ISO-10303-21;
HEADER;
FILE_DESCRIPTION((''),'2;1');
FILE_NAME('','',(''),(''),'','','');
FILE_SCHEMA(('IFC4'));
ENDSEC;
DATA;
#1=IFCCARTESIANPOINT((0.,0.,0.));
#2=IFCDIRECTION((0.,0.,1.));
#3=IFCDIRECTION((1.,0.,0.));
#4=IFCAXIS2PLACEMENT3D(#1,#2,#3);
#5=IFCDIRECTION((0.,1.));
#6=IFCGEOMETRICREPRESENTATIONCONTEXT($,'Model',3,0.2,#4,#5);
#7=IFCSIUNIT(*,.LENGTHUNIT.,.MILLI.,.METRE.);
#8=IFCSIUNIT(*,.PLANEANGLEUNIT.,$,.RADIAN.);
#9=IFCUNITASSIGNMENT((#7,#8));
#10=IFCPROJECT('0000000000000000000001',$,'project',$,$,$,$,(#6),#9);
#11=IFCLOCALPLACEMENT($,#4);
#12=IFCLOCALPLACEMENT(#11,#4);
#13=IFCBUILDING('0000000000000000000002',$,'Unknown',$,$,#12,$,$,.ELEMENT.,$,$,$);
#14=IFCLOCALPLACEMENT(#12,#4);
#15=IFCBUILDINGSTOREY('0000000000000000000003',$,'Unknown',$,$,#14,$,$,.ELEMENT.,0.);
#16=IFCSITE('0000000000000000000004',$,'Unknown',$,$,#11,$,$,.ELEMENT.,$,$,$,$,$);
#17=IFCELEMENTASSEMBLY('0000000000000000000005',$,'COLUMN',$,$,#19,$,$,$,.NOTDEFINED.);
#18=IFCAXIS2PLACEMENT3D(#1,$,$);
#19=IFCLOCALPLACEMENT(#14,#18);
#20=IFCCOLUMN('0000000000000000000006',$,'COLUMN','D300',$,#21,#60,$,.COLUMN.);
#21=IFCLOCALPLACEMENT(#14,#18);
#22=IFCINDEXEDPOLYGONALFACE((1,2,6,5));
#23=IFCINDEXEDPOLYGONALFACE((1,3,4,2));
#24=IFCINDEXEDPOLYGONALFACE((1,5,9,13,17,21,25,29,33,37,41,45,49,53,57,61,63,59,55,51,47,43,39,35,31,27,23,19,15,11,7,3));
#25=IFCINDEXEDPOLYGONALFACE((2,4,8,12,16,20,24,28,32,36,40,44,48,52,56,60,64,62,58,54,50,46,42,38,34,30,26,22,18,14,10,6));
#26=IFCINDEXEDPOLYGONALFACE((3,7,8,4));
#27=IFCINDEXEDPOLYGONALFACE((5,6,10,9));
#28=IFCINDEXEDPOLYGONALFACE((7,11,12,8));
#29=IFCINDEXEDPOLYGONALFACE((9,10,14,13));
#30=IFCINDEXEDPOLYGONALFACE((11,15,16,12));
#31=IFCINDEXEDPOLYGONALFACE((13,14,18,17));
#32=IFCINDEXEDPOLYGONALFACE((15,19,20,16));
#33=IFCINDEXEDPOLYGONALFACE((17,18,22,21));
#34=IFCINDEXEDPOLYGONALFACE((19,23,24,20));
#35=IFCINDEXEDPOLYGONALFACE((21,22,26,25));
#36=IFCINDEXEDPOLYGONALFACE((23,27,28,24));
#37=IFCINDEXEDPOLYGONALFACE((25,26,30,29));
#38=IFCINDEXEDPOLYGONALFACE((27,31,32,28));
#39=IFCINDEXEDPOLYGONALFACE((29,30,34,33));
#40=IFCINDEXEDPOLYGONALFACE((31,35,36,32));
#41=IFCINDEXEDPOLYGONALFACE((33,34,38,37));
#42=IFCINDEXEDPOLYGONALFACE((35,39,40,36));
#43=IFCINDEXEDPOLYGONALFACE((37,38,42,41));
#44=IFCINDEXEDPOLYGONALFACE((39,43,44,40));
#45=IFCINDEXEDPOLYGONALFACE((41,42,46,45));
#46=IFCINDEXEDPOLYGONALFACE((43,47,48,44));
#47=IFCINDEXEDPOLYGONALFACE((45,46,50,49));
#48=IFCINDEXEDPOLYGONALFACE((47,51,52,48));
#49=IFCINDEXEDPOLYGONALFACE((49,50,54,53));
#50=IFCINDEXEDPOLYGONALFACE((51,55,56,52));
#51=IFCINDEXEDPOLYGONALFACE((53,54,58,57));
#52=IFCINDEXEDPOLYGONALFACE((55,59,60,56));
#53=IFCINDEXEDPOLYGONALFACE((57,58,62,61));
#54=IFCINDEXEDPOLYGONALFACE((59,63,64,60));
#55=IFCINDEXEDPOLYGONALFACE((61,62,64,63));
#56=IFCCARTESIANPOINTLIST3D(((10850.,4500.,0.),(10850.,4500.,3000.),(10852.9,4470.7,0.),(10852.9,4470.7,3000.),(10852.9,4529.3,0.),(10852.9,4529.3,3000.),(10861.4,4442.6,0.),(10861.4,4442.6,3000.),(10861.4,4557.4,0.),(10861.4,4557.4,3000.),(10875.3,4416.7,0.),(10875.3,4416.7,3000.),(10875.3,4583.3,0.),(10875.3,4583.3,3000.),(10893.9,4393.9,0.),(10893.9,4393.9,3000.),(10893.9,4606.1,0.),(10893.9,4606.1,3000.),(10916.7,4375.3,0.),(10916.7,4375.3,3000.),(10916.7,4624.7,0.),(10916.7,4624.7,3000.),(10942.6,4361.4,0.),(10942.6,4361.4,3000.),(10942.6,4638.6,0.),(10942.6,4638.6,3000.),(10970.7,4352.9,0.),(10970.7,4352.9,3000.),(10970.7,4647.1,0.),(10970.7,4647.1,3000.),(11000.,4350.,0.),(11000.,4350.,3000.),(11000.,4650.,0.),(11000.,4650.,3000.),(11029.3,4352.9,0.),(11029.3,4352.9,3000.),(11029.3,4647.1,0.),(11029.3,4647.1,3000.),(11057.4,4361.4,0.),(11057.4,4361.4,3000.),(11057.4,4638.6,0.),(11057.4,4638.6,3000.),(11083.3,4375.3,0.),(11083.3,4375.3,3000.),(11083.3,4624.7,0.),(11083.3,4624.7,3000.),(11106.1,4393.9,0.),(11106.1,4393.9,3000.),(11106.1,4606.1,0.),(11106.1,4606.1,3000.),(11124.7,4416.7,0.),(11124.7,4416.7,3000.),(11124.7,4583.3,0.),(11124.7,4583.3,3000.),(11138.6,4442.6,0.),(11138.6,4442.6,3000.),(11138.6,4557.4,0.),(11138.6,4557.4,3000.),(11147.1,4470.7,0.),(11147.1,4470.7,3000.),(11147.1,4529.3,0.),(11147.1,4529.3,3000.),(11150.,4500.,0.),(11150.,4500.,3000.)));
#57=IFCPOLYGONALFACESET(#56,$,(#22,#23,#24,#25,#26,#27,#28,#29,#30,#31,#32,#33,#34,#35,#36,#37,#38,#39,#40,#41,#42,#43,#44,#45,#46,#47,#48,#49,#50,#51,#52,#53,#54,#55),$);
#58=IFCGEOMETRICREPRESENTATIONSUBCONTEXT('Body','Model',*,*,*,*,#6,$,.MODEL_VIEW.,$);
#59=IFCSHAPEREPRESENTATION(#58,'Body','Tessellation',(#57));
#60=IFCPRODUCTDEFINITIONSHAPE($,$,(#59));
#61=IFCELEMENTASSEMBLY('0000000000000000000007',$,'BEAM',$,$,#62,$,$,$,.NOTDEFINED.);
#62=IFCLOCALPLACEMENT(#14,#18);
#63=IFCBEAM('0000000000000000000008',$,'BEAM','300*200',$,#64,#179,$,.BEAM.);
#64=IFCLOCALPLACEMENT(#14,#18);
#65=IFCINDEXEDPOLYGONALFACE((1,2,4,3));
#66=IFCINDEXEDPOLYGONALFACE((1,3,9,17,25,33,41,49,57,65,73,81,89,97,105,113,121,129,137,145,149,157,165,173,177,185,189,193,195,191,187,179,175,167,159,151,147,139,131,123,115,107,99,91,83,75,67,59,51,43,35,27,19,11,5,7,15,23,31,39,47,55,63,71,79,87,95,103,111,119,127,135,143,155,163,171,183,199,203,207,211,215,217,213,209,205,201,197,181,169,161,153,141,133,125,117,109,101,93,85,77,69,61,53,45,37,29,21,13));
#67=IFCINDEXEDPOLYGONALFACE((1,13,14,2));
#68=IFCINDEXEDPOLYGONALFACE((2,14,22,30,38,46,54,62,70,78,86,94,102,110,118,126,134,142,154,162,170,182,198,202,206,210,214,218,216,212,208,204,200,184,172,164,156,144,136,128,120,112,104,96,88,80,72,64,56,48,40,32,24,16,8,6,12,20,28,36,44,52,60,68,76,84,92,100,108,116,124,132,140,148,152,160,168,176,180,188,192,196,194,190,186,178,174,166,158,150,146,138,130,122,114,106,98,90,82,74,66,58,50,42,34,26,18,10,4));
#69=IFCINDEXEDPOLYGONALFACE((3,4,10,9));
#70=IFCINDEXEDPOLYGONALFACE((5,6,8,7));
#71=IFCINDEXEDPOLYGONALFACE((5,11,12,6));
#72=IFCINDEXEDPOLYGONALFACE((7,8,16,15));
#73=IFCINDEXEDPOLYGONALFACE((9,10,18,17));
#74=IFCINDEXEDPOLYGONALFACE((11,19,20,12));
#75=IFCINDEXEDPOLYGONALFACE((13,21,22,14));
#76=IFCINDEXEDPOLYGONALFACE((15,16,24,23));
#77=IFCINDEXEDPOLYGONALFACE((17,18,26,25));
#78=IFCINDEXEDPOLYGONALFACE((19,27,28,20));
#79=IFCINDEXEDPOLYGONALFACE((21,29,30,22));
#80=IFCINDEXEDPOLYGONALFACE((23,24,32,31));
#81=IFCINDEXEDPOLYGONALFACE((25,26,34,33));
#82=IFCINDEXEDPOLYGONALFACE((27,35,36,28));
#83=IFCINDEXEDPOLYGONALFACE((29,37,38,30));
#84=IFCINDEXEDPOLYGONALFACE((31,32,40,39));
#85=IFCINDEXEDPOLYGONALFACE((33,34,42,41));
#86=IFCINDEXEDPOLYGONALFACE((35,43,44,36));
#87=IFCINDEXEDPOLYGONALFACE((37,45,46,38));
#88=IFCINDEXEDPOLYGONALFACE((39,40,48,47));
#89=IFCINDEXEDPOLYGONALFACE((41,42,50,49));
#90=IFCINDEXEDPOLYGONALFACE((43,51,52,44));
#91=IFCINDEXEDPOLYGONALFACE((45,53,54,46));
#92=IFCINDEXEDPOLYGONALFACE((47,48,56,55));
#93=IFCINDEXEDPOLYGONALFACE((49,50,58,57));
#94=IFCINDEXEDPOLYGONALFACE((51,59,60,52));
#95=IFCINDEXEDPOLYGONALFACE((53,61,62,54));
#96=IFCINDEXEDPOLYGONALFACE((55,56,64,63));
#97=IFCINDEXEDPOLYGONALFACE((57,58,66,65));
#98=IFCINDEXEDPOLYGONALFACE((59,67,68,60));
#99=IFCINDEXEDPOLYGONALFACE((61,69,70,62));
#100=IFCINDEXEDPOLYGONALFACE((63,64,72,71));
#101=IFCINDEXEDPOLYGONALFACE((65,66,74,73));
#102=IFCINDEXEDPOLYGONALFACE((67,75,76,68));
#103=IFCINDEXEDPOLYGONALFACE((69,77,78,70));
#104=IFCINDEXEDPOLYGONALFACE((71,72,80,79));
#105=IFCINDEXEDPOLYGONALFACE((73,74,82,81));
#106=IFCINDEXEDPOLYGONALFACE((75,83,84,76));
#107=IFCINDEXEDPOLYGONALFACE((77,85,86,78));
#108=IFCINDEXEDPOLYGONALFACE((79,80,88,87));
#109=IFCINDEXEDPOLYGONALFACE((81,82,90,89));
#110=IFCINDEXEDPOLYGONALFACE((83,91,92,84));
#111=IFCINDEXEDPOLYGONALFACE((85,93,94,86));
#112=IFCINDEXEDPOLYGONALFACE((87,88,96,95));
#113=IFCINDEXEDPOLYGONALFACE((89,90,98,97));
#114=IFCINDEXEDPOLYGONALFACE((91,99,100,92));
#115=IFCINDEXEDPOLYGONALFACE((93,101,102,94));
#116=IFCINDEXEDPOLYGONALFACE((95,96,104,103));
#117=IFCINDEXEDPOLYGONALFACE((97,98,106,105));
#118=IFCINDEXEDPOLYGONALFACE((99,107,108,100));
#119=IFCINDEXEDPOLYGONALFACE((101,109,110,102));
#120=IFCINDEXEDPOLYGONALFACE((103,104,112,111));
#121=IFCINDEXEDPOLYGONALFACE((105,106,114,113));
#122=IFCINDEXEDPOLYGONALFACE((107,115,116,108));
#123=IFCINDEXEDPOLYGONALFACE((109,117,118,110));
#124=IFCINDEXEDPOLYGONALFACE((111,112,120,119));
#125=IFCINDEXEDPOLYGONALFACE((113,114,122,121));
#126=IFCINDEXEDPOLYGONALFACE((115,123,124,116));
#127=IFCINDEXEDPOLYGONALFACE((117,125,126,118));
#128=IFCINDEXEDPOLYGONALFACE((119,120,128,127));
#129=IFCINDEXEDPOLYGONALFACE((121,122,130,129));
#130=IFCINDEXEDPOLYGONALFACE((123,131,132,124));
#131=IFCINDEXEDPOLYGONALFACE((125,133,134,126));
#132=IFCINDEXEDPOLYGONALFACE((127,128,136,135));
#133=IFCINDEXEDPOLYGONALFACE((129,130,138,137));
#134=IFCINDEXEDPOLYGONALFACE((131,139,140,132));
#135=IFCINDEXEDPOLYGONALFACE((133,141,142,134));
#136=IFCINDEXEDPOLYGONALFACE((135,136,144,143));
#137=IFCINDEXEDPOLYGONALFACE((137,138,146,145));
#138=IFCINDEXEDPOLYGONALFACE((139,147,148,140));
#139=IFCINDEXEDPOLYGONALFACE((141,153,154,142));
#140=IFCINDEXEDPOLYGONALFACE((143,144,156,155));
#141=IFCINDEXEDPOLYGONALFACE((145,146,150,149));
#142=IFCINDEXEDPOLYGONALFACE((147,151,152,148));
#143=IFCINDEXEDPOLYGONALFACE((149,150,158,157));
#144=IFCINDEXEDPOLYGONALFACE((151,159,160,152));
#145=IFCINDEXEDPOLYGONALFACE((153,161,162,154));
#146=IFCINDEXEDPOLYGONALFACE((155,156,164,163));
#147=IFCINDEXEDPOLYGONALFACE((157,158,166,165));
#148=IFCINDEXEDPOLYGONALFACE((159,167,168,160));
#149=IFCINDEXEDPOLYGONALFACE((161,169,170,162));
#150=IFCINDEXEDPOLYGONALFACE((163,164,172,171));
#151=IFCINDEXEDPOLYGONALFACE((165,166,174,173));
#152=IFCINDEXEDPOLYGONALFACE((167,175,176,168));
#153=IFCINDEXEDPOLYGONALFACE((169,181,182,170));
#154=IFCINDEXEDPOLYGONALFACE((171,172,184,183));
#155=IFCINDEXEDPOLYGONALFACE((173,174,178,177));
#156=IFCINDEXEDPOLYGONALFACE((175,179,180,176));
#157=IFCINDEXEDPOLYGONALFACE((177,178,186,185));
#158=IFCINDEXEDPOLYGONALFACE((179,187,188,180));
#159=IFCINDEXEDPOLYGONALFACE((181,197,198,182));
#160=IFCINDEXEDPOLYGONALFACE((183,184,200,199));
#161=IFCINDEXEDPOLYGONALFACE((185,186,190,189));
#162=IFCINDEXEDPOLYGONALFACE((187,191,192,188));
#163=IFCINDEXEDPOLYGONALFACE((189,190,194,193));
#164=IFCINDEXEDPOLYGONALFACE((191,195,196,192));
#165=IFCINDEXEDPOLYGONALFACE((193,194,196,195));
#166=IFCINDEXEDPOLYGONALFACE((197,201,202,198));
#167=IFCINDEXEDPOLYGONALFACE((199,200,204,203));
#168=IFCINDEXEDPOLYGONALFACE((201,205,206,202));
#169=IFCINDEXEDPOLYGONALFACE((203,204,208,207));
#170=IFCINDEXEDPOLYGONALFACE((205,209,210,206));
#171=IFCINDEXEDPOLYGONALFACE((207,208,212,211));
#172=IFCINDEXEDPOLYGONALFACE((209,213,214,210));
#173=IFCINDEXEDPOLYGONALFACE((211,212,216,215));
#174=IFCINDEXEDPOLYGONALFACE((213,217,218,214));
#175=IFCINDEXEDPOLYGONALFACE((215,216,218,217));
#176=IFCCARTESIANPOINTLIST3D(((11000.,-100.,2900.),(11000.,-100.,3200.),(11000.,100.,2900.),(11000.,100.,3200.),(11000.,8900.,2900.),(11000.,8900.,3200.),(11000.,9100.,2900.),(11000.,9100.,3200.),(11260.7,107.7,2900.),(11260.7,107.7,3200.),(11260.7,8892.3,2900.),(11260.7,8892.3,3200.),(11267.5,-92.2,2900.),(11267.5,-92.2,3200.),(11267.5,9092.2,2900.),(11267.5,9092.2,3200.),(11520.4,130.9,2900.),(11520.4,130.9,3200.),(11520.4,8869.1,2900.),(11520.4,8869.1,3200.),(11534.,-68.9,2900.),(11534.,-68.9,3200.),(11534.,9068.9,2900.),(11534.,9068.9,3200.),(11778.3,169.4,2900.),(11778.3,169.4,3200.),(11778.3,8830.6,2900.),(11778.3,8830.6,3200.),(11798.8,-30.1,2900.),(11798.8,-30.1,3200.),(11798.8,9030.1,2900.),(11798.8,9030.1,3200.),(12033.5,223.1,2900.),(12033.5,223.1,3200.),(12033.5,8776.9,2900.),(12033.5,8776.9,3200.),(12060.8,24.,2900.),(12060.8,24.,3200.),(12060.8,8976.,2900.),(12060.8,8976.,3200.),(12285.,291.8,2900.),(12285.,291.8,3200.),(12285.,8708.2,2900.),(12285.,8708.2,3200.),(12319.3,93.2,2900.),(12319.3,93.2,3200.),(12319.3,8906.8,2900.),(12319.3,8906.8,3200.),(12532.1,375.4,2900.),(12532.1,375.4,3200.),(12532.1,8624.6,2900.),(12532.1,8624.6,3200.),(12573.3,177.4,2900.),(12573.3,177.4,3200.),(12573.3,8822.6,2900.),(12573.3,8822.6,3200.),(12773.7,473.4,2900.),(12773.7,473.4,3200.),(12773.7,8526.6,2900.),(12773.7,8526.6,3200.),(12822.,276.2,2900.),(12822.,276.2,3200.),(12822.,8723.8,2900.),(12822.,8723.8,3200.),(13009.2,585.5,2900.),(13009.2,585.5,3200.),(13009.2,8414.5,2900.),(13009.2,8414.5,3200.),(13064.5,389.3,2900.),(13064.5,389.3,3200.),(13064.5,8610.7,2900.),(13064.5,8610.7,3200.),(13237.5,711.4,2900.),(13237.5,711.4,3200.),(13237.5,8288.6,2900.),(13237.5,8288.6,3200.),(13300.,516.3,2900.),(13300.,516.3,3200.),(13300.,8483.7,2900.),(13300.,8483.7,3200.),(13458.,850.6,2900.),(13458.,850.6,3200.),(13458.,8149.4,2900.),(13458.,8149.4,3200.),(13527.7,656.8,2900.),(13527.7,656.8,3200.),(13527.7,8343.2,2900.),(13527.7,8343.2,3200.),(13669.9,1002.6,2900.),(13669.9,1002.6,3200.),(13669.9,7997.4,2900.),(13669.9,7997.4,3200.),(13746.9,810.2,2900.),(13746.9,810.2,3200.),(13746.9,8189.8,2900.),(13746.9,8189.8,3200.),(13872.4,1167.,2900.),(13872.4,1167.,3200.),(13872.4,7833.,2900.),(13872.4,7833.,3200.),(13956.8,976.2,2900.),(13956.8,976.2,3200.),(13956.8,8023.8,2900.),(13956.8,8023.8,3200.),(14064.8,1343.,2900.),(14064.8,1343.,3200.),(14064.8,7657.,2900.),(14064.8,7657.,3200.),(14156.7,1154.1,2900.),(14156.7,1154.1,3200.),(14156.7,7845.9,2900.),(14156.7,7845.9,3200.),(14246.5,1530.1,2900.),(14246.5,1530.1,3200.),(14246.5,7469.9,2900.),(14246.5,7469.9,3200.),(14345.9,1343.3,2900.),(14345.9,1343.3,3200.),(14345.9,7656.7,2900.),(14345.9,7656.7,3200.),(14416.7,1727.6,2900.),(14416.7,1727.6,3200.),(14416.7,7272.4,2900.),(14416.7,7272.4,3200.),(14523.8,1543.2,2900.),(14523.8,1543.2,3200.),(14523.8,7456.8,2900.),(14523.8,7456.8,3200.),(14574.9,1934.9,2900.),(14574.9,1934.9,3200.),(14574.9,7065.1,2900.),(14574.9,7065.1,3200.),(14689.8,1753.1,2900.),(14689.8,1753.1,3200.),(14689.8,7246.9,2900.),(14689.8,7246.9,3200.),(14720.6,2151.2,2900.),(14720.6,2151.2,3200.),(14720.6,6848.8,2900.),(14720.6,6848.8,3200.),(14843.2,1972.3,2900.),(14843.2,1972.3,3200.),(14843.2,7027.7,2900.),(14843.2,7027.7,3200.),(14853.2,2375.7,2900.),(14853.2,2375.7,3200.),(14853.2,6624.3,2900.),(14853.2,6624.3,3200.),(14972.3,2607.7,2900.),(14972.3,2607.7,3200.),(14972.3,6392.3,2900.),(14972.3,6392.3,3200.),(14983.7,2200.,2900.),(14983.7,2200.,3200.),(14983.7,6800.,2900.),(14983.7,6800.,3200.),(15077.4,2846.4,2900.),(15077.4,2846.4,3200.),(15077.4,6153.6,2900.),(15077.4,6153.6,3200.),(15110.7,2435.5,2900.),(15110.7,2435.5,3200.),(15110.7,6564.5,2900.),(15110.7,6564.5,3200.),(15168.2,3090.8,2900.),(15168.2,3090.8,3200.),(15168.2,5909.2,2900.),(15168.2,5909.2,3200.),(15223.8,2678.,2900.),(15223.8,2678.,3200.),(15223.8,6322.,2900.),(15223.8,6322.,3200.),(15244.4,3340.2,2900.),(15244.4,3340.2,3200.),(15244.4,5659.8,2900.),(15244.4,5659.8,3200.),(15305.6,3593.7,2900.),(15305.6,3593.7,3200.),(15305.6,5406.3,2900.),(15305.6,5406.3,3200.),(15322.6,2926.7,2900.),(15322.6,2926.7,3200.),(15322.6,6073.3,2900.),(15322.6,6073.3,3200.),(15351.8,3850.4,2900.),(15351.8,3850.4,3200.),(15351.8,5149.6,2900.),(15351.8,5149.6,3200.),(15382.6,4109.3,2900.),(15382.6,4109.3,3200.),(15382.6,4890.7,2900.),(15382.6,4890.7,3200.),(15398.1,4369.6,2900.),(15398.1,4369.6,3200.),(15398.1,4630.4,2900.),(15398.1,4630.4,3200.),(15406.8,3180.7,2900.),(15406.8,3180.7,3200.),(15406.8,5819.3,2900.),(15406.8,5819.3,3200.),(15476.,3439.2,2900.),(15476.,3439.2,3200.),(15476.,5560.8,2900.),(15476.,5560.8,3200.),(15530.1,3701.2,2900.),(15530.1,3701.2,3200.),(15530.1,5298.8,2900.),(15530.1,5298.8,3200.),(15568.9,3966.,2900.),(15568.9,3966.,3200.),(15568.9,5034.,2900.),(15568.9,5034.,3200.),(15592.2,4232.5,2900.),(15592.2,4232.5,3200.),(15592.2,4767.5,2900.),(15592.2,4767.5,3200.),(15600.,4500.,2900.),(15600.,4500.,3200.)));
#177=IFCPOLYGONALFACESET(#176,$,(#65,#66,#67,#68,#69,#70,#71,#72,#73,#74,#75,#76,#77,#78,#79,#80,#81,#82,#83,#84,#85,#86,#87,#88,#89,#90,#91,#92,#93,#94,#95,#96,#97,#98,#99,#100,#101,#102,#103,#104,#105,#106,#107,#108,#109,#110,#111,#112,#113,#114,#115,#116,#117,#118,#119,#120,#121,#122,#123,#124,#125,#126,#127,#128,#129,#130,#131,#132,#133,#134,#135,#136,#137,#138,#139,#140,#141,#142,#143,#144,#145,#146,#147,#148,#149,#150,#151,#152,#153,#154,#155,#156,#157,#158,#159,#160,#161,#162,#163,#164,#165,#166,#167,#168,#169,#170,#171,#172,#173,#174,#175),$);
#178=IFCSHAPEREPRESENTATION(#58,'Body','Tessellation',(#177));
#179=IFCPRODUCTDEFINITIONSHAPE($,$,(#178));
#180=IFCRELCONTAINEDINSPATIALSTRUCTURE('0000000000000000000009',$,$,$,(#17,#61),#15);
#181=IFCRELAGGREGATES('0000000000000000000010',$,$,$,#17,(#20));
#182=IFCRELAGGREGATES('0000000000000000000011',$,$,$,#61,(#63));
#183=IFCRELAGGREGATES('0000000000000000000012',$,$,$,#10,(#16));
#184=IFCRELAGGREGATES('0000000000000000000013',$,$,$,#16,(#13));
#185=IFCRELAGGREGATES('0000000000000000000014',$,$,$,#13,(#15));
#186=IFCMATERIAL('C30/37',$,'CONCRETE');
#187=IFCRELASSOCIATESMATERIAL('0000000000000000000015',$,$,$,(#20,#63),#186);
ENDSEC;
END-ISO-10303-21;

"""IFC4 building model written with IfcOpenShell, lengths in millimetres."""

from ifc_helpers import new_model, entity, si_unit, direction, frame, origin_with_axes, place, context, subcontext, project, spatial, line, indexed_curve, outline, extrude, material, element, aggregate, save


model = new_model("IFC4")

# Units and contexts
model_context = context("Model", 3, precision=0.2, world=origin_with_axes(), true_north=direction((0.0, 1.0)))
body_context = subcontext(model_context, "Body", "Model", "MODEL_VIEW")
ifc_project = project(units=[si_unit("LENGTHUNIT", "METRE", prefix="MILLI"), si_unit("PLANEANGLEUNIT", "RADIAN")], contexts=[model_context])

# Site, building, storey
site_placement = place(None, origin_with_axes())
site = spatial("IfcSite", under=ifc_project, at=site_placement, Name="Unknown", CompositionType="ELEMENT")
building_placement = place(site_placement, origin_with_axes())
building = spatial("IfcBuilding", under=site, at=building_placement, Name="Unknown", CompositionType="ELEMENT")
storey_placement = place(building_placement, origin_with_axes())
storey = spatial("IfcBuildingStorey", under=building, at=storey_placement, Name="Unknown", CompositionType="ELEMENT", Elevation=0.0)

# Shared definitions
ifc_material_1 = material(Name="C30/37", Category="CONCRETE")

# Element assembly, column, voiding feature
assembly_1_placement = place(storey_placement, frame((11000.0, 4500.0, 0.0), z_axis=(-1.0, 0.0, 0.0), x_axis=(0.0, 0.0, 1.0)))
assembly_1 = element("IfcElementAssembly", 1, at=assembly_1_placement, inside=storey, Name="COLUMN", PredefinedType="NOTDEFINED")
column_1_placement = place(assembly_1_placement, origin_with_axes())
column_1 = element("IfcColumn", 2, at=column_1_placement, material=ifc_material_1, Name="COLUMN", Description="D300", PredefinedType="COLUMN", context=body_context, shape_type="SolidModel", body=[
    extrude(outline(indexed_curve([(150.0, 0.0), (147.1, 29.3), (138.6, 57.4), (124.7, 83.3), (106.1, 106.1), (83.3, 124.7), (57.4, 138.6), (29.3, 147.1), (0.0, 150.0), (-29.3, 147.1), (-57.4, 138.6), (-83.3, 124.7), (-106.1, 106.1), (-124.7, 83.3), (-138.6, 57.4), (-147.1, 29.3), (-150.0, 0.0), (-147.1, -29.3), (-138.6, -57.4), (-124.7, -83.3), (-106.1, -106.1), (-83.3, -124.7), (-57.4, -138.6), (-29.3, -147.1), (0.0, -150.0), (29.3, -147.1), (57.4, -138.6), (83.3, -124.7), (106.1, -106.1), (124.7, -83.3), (138.6, -57.4), (147.1, -29.3)], segments=[line(1, 2, 3, 4, 5, 6, 7, 8, 9, 10, 11, 12, 13, 14, 15, 16, 17, 18, 19, 20, 21, 22, 23, 24, 25, 26, 27, 28, 29, 30, 31, 32, 1)])), frame((0.0, 0.0, 0.0), z_axis=(-1.0, 0.0, 0.0), x_axis=(0.0, 0.0, 1.0)), (0.0, 0.0, -1.0), 3200.0),
])
voiding_feature_1_placement = place(column_1_placement, frame((3100.0, -4650.0, 11150.0), z_axis=(1.0, 0.0, 0.0), x_axis=(0.0, 0.0, -1.0)))
element("IfcVoidingFeature", 3, at=voiding_feature_1_placement, cuts=column_1, Name="SLAB", PredefinedType="HOLE", context=body_context, shape_type="SolidModel", body=[
    extrude(outline(indexed_curve([(0.0, 0.0), (11300.0, 0.0), (11300.0, 9300.0), (0.0, 9300.0)], segments=[line(1, 2, 3, 4, 1)])), frame((0.0, 0.0, 100.0), z_axis=(0.0, 0.0, 1.0), x_axis=(1.0, 0.0, 0.0)), (0.0, 0.0, -1.0), 200.0),
])
aggregate(assembly_1, [column_1])

# Element assembly, beam
assembly_2_placement = place(storey_placement, frame((11000.0, 9000.0, 3050.0), z_axis=(-1.0, 0.0, 0.0), x_axis=(0.0, -1.0, 0.0)))
assembly_2 = element("IfcElementAssembly", 4, at=assembly_2_placement, inside=storey, Name="BEAM", PredefinedType="NOTDEFINED")
beam_1_placement = place(assembly_2_placement, origin_with_axes())
beam_1 = element("IfcBeam", 5, at=beam_1_placement, material=ifc_material_1, Name="BEAM", Description="300*200", PredefinedType="BEAM", context=body_context, shape_type="SolidModel", body=[
    entity("IfcRevolvedAreaSolid", entity("IfcArbitraryClosedProfileDef", "AREA", None, entity("IfcIndexedPolyCurve", entity("IfcCartesianPointList2D", [[-100.0, -150.0], [100.0, -150.0], [100.0, 150.0], [-100.0, 150.0]]), [entity("IfcLineIndex", [1, 2, 3, 4, 1])])), entity("IfcAxis2Placement3D", entity("IfcCartesianPoint", [0.0, 0.0, 0.0]), entity("IfcDirection", [0.0, 0.0, 1.0]), entity("IfcDirection", [1.0, 0.0, 0.0])), entity("IfcAxis1Placement", entity("IfcCartesianPoint", [4500.0, 0.0, 0.0]), entity("IfcDirection", [0.0, 1.0, 0.0])), -3.141593),
])
aggregate(assembly_2, [beam_1])

save(model, "model.ifc")
